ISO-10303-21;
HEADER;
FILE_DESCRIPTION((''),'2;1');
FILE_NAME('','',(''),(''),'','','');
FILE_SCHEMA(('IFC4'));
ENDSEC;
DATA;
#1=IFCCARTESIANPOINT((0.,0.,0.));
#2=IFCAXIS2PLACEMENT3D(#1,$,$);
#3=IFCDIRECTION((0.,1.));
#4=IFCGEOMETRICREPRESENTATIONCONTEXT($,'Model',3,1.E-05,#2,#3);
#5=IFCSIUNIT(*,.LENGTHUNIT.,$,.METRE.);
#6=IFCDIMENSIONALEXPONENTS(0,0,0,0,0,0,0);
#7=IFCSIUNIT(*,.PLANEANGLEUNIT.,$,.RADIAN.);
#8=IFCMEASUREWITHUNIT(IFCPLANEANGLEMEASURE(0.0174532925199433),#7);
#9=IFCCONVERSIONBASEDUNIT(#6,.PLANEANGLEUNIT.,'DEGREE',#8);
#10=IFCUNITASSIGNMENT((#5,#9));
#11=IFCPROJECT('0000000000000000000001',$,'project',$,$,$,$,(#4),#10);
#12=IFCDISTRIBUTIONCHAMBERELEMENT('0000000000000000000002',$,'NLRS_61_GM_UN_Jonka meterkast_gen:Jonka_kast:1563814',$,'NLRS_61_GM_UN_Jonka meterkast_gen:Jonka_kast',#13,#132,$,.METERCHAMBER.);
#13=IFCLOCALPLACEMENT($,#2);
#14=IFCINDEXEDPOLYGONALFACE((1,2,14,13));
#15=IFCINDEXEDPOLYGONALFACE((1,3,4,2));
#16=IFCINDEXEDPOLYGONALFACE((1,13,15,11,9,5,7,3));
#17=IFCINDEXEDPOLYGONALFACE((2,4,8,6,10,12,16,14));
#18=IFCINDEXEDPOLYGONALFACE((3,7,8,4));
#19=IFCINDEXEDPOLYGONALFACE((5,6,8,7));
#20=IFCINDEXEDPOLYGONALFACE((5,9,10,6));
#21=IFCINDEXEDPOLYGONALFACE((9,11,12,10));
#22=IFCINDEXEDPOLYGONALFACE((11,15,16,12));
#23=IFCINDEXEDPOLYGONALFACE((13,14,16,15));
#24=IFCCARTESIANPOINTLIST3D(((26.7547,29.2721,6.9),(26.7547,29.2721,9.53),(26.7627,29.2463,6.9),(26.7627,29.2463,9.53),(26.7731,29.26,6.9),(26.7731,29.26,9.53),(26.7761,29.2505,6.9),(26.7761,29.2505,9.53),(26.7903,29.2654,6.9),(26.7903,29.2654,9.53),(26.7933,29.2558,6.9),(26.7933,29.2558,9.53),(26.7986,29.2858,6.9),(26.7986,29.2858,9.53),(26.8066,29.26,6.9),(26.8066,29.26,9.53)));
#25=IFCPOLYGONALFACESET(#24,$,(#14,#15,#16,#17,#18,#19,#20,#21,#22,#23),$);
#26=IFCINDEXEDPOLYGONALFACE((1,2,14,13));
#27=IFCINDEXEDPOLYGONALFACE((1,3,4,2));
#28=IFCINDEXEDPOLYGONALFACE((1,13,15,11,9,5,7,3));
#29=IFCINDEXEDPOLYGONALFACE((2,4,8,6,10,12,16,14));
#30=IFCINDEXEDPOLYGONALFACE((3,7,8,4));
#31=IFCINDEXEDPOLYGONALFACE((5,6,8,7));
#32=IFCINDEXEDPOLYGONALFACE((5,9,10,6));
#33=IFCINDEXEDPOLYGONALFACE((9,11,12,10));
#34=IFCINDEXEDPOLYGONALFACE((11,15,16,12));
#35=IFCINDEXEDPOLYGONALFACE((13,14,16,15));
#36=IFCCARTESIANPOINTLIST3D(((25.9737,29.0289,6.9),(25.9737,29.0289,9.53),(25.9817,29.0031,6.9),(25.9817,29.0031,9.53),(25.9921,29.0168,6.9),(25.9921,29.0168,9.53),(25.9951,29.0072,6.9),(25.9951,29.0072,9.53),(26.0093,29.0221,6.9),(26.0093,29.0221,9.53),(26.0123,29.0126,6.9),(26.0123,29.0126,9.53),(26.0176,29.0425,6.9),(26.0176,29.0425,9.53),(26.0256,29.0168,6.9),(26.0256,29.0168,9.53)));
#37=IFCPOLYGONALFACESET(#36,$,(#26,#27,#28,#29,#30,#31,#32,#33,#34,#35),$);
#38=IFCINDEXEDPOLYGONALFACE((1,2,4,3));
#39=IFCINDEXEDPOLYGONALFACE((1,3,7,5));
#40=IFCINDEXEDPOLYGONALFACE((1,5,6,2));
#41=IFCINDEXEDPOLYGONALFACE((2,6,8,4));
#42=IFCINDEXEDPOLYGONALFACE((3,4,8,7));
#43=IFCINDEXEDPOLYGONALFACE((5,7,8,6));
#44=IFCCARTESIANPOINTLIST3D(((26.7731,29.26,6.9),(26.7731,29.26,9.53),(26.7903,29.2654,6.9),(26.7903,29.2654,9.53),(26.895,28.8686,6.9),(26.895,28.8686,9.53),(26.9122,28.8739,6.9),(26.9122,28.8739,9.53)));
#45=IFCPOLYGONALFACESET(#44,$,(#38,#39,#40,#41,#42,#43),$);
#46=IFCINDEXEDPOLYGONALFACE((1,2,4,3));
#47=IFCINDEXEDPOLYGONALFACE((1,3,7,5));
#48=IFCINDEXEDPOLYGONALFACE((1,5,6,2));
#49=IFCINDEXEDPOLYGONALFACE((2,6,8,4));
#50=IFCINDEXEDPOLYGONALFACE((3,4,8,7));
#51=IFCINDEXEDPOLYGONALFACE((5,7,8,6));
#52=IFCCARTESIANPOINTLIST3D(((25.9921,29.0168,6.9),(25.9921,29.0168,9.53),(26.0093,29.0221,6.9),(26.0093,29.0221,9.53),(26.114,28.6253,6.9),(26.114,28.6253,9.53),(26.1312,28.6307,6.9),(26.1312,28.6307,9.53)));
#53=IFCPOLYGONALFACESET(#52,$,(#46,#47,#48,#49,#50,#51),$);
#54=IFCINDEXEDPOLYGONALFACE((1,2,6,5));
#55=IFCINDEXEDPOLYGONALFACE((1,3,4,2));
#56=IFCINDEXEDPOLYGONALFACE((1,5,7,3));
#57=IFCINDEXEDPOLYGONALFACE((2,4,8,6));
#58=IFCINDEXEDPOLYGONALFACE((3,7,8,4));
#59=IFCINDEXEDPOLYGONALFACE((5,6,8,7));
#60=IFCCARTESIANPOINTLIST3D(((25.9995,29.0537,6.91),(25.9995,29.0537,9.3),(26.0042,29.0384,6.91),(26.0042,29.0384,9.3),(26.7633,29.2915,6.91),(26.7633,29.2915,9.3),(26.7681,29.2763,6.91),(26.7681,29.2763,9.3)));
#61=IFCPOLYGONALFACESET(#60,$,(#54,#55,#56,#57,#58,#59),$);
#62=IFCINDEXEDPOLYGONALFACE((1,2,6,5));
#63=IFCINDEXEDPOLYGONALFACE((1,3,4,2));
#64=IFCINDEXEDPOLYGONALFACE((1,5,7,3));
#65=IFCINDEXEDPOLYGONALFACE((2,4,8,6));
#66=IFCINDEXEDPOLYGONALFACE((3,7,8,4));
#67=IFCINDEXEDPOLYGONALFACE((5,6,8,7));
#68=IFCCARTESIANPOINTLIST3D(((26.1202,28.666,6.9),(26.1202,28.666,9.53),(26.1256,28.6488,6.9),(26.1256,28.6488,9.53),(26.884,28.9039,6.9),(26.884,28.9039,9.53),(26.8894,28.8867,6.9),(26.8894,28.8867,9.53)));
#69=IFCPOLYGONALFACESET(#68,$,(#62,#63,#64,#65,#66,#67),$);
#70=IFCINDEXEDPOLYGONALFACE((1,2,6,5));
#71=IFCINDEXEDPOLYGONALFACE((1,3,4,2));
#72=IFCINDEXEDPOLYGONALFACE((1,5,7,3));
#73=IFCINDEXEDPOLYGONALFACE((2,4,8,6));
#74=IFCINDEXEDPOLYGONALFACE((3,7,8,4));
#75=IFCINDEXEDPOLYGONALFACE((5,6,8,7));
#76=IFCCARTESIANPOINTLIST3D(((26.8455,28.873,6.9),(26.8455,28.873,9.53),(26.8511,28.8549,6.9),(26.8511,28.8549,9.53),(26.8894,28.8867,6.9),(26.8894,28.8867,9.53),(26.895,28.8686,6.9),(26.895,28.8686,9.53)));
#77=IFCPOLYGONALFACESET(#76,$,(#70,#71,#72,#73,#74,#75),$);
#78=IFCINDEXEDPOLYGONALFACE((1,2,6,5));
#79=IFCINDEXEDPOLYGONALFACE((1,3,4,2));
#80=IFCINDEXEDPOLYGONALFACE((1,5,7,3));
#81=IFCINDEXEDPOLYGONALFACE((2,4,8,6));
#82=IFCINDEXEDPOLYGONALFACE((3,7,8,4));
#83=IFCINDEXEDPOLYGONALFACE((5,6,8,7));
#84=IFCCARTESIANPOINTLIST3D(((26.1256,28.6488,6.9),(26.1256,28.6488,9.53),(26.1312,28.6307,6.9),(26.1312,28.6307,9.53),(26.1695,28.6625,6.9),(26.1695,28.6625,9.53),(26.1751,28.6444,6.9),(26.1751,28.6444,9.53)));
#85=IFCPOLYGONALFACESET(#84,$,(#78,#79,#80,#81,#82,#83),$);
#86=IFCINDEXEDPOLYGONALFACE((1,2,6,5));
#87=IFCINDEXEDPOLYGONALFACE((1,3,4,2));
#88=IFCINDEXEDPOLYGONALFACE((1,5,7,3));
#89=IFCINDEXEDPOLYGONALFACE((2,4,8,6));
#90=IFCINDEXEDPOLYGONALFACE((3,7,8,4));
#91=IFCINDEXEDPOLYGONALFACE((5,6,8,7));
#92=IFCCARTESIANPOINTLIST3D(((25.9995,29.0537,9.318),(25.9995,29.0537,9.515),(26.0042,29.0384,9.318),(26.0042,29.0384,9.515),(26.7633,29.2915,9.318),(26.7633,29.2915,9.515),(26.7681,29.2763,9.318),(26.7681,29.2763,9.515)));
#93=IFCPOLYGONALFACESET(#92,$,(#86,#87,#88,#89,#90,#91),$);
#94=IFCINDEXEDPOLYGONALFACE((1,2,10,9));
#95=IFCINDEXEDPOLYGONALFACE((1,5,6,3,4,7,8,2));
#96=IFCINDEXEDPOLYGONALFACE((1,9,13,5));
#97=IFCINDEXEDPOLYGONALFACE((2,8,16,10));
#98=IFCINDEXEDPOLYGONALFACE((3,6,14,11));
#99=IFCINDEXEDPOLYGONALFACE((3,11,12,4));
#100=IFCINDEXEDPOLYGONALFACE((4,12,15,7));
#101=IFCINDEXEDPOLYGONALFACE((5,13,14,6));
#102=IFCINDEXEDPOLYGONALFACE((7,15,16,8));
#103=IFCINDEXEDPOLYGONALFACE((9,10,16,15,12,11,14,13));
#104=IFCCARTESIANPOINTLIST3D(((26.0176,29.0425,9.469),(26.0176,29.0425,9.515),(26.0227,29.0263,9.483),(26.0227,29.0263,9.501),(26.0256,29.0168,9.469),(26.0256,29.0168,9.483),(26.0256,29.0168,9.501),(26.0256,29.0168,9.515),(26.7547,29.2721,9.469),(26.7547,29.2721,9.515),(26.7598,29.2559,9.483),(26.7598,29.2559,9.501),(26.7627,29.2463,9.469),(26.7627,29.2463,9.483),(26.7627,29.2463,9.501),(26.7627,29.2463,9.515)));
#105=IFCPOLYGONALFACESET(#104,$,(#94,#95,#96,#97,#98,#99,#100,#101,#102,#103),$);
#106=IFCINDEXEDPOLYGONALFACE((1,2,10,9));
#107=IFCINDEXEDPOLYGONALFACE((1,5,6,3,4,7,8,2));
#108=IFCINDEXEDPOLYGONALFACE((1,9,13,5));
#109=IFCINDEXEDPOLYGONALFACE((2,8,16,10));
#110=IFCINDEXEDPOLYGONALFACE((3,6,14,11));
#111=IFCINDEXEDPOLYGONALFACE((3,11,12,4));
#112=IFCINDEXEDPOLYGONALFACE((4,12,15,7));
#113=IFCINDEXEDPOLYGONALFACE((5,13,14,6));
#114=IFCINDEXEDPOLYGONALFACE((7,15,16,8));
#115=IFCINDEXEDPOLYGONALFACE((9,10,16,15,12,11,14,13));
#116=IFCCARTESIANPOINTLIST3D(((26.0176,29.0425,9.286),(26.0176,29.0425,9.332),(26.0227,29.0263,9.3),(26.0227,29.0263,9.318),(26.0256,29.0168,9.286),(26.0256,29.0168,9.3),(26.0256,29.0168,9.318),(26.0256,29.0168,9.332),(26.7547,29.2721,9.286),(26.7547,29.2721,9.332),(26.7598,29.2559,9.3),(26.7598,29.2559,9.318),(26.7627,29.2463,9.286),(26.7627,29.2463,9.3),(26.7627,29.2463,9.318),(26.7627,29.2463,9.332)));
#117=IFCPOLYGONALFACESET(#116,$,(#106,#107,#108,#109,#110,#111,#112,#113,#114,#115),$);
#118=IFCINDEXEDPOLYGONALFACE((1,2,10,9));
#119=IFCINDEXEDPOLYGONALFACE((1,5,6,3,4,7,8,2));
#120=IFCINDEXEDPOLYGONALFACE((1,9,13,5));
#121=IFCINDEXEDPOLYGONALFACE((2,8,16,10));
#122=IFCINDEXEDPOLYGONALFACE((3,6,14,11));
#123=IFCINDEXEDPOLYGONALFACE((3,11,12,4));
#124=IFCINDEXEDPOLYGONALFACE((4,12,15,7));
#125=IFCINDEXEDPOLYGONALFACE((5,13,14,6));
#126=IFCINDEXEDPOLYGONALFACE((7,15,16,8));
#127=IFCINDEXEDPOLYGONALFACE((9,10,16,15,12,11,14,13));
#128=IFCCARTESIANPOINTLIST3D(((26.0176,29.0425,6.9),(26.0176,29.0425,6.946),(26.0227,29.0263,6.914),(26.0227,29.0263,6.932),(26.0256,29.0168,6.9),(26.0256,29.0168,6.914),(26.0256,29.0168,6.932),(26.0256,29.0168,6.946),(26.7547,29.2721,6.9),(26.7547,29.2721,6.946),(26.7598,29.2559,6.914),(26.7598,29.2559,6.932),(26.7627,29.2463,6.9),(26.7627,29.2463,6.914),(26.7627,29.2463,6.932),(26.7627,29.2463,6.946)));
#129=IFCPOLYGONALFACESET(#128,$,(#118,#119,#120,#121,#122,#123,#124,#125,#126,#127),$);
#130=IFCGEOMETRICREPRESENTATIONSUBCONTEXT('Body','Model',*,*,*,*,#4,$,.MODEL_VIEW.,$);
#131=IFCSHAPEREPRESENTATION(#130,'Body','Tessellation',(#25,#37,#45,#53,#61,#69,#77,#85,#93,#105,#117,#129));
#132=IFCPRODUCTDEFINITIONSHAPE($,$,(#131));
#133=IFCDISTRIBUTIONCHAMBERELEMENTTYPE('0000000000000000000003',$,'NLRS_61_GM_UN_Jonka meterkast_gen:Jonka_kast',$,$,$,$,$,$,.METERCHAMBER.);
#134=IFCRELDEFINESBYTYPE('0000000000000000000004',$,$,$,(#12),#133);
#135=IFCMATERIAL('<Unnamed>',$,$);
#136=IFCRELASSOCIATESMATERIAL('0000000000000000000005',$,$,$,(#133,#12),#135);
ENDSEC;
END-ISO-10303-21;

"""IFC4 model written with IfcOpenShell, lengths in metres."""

from ifc_helpers import new_model, entity, si_unit, converted_unit, direction, frame, origin, place, context, subcontext, project, indexed_curve, outline, extrude, source, transform, mapped, material, type_object, type_shapes, element, save


model = new_model("IFC4")

# Units and contexts
model_context = context("Model", 3, precision=1e-05, world=origin(), true_north=direction((0.0, 1.0)))
body_context = subcontext(model_context, "Body", "Model", "MODEL_VIEW")
ifc_project = project(units=[si_unit("LENGTHUNIT", "METRE"), converted_unit("PLANEANGLEUNIT", "DEGREE", entity("IfcPlaneAngleMeasure", 0.0174532925199433), si_unit("PLANEANGLEUNIT", "RADIAN"), dimensions=[0, 0, 0, 0, 0, 0, 0])], contexts=[model_context])

# Distribution chamber element
ifc_material = material(Name="<Unnamed>")
distribution_chamber_element_type = type_object("IfcDistributionChamberElementType", Name="NLRS_61_GM_UN_Jonka meterkast_gen:Jonka_kast", PredefinedType="METERCHAMBER", material=ifc_material)
shared_shape_1 = source(origin(), body_context, "Body", "SweptSolid", [
    extrude(outline(indexed_curve([(-0.0093, -0.023), (0.0178, -0.023), (0.0178, 0.023), (-0.0093, 0.023), (-0.0093, 0.009), (0.0007, 0.009), (0.0007, -0.009), (-0.0093, -0.009), (-0.0093, -0.023)], self_intersect=False)), frame((-0.409, -0.4092, 0.0), z_axis=(0.0, 0.0, 1.0), x_axis=(0.0, -1.0, 0.0)), (0.0, 0.0, 1.0), 2.63),
    extrude(outline(indexed_curve([(-0.0093, -0.023), (0.0178, -0.023), (0.0178, 0.023), (-0.0093, 0.023), (-0.0093, 0.009), (0.0007, 0.009), (0.0007, -0.009), (-0.0093, -0.009), (-0.0093, -0.023)], self_intersect=False)), frame((0.409, -0.4092, 0.0), z_axis=(0.0, 0.0, 1.0), x_axis=(0.0, -1.0, 0.0)), (0.0, 0.0, 1.0), 2.63),
    extrude(outline(indexed_curve([(-0.205, -0.009), (0.205, -0.009), (0.205, 0.009), (-0.205, 0.009), (-0.205, -0.009)], self_intersect=False)), frame((-0.409, -0.205, 0.0), z_axis=(0.0, 0.0, 1.0), x_axis=(0.0, -1.0, 0.0)), (0.0, 0.0, 1.0), 2.63),
    extrude(outline(indexed_curve([(-0.205, -0.009), (0.205, -0.009), (0.205, 0.009), (-0.205, 0.009), (-0.205, -0.009)], self_intersect=False)), frame((0.409, -0.205, 0.0), z_axis=(0.0, 0.0, 1.0), x_axis=(0.0, -1.0, 0.0)), (0.0, 0.0, 1.0), 2.63),
    extrude(outline(indexed_curve([(-0.4, -0.008), (0.4, -0.008), (0.4, 0.008), (-0.4, 0.008), (-0.4, -0.008)], self_intersect=False)), frame((0.0, -0.435, 0.01), z_axis=(0.0, 0.0, 1.0), x_axis=(-1.0, 0.0, 0.0)), (0.0, 0.0, 1.0), 2.39),
    extrude(outline(indexed_curve([(-0.4, -0.009), (0.4, -0.009), (0.4, 0.009), (-0.4, 0.009), (-0.4, -0.009)], self_intersect=False)), frame((0.0, -0.028, 0.0), z_axis=(0.0, 0.0, 1.0), x_axis=(-1.0, 0.0, 0.0)), (0.0, 0.0, 1.0), 2.63),
    extrude(outline(indexed_curve([(-0.023, -0.0095), (0.023, -0.0095), (0.023, 0.0095), (-0.023, 0.0095), (-0.023, -0.0095)], self_intersect=False)), frame((-0.377, -0.0095, 0.0), z_axis=(0.0, 0.0, 1.0), x_axis=(-1.0, 0.0, 0.0)), (0.0, 0.0, 1.0), 2.63),
    extrude(outline(indexed_curve([(-0.023, -0.0095), (0.023, -0.0095), (0.023, 0.0095), (-0.023, 0.0095), (-0.023, -0.0095)], self_intersect=False)), frame((0.377, -0.0095, 0.0), z_axis=(0.0, 0.0, 1.0), x_axis=(-1.0, 0.0, 0.0)), (0.0, 0.0, 1.0), 2.63),
    extrude(outline(indexed_curve([(-0.4, -0.008), (0.4, -0.008), (0.4, 0.008), (-0.4, 0.008), (-0.4, -0.008)], self_intersect=False)), frame((0.0, -0.435, 2.418), z_axis=(0.0, 0.0, 1.0), x_axis=(-1.0, 0.0, 0.0)), (0.0, 0.0, 1.0), 0.197),
    extrude(outline(indexed_curve([(-0.023, -0.0178), (0.023, -0.0178), (0.023, 0.0093), (0.009, 0.0093), (0.009, -0.0007), (-0.009, -0.0007), (-0.009, 0.0093), (-0.023, 0.0093), (-0.023, -0.0178)], self_intersect=False)), frame((-0.386, -0.4092, 2.592), z_axis=(1.0, 0.0, 0.0), x_axis=(0.0, 0.0, -1.0)), (0.0, 0.0, 1.0), 0.772),
    extrude(outline(indexed_curve([(-0.023, -0.0178), (0.023, -0.0178), (0.023, 0.0093), (0.009, 0.0093), (0.009, -0.0007), (-0.009, -0.0007), (-0.009, 0.0093), (-0.023, 0.0093), (-0.023, -0.0178)], self_intersect=False)), frame((-0.386, -0.4092, 2.409), z_axis=(1.0, 0.0, 0.0), x_axis=(0.0, 0.0, -1.0)), (0.0, 0.0, 1.0), 0.772),
    extrude(outline(indexed_curve([(-0.023, -0.0178), (0.023, -0.0178), (0.023, 0.0093), (0.009, 0.0093), (0.009, -0.0007), (-0.009, -0.0007), (-0.009, 0.0093), (-0.023, 0.0093), (-0.023, -0.0178)], self_intersect=False)), frame((-0.386, -0.4092, 0.023), z_axis=(1.0, 0.0, 0.0), x_axis=(0.0, 0.0, -1.0)), (0.0, 0.0, 1.0), 0.772),
])
type_shapes(distribution_chamber_element_type, [shared_shape_1])
placement_1 = place(None, frame((13.1348, 11.9886, 0.0), z_axis=(0.0, 0.0, 1.0), x_axis=(0.954771, 0.297342, 0.0)))
placement_2 = place(placement_1, origin())
placement_3 = place(placement_2, frame((0.0, 0.0, 6.9)))
placement_4 = place(placement_3, origin())
distribution_chamber_element_1_placement = place(placement_4, frame((17.757, 12.025, 0.0), z_axis=(0.0, 0.0, 1.0), x_axis=(-1.0, 0.0, 0.0)))
element("IfcDistributionChamberElement", 1, at=distribution_chamber_element_1_placement, type_object=distribution_chamber_element_type, material=ifc_material, Name="NLRS_61_GM_UN_Jonka meterkast_gen:Jonka_kast:1563814", ObjectType="NLRS_61_GM_UN_Jonka meterkast_gen:Jonka_kast", PredefinedType="METERCHAMBER", context=body_context, shape_type="MappedRepresentation", body=[
    mapped(shared_shape_1, transform((0.0, 0.0, 0.0), scale=1.0)),
])

save(model, "model.ifc")
